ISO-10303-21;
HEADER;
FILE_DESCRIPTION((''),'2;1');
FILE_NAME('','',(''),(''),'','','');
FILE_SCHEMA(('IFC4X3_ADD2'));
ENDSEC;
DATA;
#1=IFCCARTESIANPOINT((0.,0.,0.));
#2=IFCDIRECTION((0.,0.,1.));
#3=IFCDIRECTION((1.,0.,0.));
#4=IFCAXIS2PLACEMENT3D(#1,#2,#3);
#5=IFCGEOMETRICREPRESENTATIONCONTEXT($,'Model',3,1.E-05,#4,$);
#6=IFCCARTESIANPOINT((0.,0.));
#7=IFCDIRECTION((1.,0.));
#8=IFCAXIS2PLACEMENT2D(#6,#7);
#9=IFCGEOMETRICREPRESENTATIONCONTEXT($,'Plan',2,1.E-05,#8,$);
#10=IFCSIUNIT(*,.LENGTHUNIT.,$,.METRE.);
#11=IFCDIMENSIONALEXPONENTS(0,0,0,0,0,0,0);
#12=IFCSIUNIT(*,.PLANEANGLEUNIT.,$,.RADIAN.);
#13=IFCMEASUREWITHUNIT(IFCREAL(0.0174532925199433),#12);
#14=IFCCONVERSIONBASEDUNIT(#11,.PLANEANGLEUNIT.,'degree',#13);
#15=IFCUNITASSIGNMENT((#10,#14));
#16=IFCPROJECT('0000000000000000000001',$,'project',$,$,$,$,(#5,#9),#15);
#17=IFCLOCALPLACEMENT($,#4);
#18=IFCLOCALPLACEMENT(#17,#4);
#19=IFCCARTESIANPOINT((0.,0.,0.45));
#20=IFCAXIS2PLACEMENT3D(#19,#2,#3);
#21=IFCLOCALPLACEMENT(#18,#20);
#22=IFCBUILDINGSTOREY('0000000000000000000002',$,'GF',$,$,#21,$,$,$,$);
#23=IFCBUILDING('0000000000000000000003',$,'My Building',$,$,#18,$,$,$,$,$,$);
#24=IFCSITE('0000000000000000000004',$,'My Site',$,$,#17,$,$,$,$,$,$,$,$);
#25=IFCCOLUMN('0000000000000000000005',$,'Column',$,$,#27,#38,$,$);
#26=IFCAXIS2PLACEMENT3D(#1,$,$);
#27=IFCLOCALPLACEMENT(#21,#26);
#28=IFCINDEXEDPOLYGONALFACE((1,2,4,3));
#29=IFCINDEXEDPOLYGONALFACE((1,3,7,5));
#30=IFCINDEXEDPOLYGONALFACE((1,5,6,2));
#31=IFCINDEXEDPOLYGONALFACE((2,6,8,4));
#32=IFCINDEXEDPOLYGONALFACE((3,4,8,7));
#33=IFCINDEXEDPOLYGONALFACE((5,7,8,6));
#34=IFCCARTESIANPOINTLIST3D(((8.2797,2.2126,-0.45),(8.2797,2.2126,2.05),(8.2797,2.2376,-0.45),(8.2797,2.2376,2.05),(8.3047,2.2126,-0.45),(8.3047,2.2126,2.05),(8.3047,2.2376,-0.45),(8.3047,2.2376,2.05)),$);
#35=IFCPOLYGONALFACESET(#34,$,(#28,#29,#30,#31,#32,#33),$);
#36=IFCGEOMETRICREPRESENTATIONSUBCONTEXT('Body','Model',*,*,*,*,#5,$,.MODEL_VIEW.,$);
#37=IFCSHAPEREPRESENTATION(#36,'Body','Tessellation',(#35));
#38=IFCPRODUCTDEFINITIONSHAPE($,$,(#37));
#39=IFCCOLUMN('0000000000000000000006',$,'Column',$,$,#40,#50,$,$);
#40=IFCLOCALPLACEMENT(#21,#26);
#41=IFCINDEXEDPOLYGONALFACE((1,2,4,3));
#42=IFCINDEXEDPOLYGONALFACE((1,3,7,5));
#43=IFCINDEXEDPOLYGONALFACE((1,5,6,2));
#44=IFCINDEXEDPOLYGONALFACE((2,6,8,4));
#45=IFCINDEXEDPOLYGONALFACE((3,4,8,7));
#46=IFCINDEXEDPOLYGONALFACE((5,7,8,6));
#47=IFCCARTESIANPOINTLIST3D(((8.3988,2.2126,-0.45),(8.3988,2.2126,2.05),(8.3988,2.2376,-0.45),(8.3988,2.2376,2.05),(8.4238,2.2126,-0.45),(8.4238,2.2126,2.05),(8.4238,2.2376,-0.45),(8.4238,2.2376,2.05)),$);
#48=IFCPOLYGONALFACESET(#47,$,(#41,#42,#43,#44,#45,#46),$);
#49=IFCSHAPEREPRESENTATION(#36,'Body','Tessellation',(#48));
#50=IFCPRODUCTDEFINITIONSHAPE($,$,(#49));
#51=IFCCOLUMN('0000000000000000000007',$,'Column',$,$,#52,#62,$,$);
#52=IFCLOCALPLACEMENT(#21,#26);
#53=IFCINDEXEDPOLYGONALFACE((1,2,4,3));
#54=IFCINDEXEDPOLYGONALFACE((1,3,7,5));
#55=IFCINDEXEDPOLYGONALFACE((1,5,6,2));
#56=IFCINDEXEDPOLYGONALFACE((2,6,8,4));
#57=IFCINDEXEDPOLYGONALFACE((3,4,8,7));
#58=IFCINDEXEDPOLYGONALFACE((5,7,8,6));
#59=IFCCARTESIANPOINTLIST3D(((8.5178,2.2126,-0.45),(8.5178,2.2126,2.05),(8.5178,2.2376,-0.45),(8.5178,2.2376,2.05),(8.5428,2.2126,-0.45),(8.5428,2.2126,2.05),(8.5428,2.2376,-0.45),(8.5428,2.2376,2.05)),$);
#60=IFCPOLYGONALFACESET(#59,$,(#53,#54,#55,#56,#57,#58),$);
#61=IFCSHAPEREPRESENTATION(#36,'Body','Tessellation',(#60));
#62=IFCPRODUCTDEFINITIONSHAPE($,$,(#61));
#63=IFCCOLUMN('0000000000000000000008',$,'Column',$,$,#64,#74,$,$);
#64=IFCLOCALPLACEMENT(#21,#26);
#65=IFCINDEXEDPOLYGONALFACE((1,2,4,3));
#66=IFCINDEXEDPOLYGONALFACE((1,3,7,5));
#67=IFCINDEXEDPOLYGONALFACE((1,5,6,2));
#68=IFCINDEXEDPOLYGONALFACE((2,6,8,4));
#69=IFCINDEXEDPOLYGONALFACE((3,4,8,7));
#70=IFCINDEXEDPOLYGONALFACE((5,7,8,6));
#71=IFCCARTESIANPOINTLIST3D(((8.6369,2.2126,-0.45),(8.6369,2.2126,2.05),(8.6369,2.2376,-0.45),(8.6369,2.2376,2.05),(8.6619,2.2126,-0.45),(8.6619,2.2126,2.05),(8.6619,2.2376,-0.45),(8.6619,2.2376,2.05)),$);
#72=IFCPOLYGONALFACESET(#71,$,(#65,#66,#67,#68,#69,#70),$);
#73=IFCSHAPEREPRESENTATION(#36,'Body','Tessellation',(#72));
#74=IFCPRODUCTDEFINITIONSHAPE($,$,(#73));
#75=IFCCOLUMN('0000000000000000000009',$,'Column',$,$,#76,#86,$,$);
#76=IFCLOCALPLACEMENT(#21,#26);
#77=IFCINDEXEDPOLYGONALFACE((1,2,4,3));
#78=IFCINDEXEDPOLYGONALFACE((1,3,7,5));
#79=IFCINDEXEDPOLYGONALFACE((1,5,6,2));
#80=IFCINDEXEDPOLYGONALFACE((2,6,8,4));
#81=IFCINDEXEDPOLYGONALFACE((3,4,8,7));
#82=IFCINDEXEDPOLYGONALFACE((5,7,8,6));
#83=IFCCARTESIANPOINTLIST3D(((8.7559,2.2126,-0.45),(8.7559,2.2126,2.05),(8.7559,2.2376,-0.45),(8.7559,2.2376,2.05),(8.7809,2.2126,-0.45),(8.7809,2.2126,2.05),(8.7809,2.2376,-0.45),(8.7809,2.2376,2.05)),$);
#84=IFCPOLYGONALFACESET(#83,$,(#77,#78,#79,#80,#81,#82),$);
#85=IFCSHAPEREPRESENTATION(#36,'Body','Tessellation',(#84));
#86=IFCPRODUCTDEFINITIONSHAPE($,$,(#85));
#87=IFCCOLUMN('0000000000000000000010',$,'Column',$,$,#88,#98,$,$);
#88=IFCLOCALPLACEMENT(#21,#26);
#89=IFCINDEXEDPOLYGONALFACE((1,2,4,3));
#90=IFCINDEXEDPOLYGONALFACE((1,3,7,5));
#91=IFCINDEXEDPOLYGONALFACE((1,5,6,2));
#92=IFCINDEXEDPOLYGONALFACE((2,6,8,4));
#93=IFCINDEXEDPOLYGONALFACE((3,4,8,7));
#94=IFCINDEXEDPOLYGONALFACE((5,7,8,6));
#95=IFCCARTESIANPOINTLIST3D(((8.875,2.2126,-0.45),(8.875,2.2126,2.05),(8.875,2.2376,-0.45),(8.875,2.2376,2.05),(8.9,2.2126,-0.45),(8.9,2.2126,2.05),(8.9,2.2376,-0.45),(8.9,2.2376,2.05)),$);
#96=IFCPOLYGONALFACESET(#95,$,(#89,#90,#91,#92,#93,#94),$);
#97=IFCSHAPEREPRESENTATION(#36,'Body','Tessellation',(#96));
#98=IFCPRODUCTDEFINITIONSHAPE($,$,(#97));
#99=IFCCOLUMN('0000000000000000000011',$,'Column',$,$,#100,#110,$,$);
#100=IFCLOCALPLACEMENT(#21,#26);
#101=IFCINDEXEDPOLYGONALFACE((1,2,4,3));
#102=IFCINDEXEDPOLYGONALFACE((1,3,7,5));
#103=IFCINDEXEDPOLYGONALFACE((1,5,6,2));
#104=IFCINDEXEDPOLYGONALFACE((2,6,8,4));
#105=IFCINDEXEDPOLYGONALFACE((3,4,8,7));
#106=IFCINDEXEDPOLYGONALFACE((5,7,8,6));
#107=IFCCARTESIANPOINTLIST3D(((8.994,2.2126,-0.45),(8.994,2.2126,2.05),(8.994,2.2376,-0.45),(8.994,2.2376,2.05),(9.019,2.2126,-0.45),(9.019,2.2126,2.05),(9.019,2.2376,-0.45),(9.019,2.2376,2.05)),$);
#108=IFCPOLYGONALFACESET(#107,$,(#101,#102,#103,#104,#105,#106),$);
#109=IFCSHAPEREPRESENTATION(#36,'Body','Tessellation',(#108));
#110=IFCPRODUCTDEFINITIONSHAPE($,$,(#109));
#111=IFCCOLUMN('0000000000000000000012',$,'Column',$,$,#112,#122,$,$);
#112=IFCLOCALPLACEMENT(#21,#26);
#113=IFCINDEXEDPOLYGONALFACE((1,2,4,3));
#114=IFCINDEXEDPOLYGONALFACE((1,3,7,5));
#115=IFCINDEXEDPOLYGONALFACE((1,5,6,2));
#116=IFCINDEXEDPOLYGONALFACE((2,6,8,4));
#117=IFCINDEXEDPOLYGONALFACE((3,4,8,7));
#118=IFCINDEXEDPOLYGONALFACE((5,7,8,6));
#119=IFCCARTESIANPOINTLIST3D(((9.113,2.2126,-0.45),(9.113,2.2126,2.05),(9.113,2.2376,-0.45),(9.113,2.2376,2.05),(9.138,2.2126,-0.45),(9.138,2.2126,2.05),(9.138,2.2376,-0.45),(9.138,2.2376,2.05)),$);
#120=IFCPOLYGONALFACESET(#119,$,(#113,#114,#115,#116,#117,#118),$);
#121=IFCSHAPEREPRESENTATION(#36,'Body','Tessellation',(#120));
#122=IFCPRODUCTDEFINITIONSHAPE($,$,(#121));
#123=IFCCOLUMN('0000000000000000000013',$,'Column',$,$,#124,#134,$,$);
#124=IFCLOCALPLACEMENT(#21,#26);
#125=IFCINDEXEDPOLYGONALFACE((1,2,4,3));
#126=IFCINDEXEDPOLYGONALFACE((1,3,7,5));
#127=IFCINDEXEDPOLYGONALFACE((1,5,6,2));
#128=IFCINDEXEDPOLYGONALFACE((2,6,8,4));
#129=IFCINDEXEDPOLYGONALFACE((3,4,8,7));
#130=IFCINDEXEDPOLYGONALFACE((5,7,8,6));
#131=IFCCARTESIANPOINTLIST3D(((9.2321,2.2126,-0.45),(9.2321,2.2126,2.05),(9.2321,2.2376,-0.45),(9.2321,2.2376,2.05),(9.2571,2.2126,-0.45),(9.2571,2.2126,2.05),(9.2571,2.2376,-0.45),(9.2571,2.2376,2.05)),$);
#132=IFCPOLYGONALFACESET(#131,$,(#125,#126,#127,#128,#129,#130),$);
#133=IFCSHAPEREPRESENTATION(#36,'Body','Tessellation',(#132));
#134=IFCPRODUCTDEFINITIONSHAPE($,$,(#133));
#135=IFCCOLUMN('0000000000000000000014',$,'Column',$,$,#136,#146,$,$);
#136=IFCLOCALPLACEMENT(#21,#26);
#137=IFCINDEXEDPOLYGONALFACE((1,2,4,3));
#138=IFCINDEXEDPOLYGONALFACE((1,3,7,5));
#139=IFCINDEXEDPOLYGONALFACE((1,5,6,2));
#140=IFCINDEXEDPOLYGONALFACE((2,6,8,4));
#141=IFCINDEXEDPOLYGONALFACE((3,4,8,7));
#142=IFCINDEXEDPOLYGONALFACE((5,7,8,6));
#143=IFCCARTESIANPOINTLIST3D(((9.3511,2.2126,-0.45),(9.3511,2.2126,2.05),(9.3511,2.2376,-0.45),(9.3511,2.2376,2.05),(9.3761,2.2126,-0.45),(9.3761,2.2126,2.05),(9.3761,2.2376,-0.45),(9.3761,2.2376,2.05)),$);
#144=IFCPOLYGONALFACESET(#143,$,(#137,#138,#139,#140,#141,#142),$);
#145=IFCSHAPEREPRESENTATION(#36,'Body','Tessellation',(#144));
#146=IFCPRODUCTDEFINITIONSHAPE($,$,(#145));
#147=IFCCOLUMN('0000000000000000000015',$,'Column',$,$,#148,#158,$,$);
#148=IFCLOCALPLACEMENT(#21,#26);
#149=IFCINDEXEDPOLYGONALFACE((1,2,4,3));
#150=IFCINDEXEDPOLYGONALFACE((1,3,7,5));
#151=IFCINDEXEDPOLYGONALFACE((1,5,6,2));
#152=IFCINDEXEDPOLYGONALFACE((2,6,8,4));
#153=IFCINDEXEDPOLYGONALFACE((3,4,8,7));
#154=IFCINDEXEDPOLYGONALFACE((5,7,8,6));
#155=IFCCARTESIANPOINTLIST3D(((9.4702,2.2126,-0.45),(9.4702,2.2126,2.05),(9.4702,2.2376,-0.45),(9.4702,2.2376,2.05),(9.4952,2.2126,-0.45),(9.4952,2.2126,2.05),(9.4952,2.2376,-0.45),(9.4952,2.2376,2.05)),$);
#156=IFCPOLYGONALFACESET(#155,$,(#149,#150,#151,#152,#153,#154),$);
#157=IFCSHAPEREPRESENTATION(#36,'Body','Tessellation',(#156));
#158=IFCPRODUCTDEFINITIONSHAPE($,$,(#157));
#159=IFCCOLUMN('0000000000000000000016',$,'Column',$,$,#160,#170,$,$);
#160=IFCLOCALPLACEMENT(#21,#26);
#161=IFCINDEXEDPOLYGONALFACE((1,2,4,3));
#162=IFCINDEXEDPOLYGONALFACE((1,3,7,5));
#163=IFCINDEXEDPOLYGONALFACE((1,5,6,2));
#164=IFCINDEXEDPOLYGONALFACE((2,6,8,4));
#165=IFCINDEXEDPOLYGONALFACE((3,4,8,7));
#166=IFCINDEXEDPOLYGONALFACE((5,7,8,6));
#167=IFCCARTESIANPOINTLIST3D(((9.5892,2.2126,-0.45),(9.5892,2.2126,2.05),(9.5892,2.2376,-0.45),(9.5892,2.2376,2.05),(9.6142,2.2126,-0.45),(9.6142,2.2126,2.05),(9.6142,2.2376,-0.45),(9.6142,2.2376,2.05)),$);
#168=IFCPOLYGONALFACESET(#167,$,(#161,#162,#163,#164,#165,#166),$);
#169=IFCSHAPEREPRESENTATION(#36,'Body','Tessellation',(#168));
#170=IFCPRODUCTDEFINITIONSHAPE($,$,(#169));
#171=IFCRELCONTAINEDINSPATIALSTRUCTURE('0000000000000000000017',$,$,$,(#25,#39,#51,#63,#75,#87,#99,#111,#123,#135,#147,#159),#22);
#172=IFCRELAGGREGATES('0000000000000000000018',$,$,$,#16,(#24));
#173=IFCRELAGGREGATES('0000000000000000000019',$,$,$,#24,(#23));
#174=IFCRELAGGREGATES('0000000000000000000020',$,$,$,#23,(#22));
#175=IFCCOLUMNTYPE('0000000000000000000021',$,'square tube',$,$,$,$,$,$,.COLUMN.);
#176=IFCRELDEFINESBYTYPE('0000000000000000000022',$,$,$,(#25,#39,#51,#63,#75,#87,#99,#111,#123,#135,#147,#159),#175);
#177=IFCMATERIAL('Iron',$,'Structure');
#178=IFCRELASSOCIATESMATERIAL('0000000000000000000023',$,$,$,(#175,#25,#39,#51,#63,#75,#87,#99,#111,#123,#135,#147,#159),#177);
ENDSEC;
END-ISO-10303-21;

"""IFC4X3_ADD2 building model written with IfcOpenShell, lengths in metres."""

from ifc_helpers import new_model, entity, si_unit, converted_unit, frame, origin_with_axes, origin_2d_with_axis, place, context, subcontext, project, spatial, indexed_curve, outline, extrude, material, material_profile, profile_set, profile_usage, type_object, element, save


model = new_model("IFC4X3_ADD2")

# Units and contexts
model_context = context("Model", 3, precision=1e-05, world=origin_with_axes())
plan_context = context("Plan", 2, precision=1e-05, world=origin_2d_with_axis())
body_context = subcontext(model_context, "Body", "Model", "MODEL_VIEW")
ifc_project = project(units=[si_unit("LENGTHUNIT", "METRE"), converted_unit("PLANEANGLEUNIT", "degree", entity("IfcReal", 0.0174532925199433), si_unit("PLANEANGLEUNIT", "RADIAN"), dimensions=[0, 0, 0, 0, 0, 0, 0])], contexts=[model_context, plan_context])

# Site, building, storey
site_placement = place(None, origin_with_axes())
site = spatial("IfcSite", under=ifc_project, at=site_placement, Name="My Site")
building_placement = place(site_placement, origin_with_axes())
building = spatial("IfcBuilding", under=site, at=building_placement, Name="My Building")
storey_placement = place(building_placement, frame((0.0, 0.0, 0.45), z_axis=(0.0, 0.0, 1.0), x_axis=(1.0, 0.0, 0.0)))
storey = spatial("IfcBuildingStorey", under=building, at=storey_placement, Name="GF")

# Columns
ifc_material_1 = material(Name="Iron", Category="Structure")
ifc_material_profile = material_profile(ifc_material_1, outline(indexed_curve([(-0.0125, -0.0125), (0.0125, -0.0125), (0.0125, 0.0125), (-0.0125, 0.0125), (-0.0125, -0.0125)])))
ifc_profile_set = profile_set([ifc_material_profile])
column_type = type_object("IfcColumnType", Name="square tube", PredefinedType="COLUMN", material=ifc_profile_set)
ifc_profile_usage_1 = profile_usage(ifc_profile_set, cardinal=5)
column_1_placement = place(storey_placement, frame((8.2922, 2.2251, -0.45), z_axis=(0.0, 0.0, 1.0), x_axis=(1.0, 0.0, 0.0)))
element("IfcColumn", 1, at=column_1_placement, inside=storey, type_object=column_type, material=ifc_profile_usage_1, Name="Column", context=body_context, shape_type="SweptSolid", body=[
    extrude(outline(indexed_curve([(-0.0125, -0.0125), (0.0125, -0.0125), (0.0125, 0.0125), (-0.0125, 0.0125), (-0.0125, -0.0125)])), origin_with_axes(), (0.0, 0.0, 1.0), 2.5),
])
ifc_profile_usage_2 = profile_usage(ifc_profile_set, cardinal=5)
column_2_placement = place(storey_placement, frame((8.4113, 2.2251, -0.45), z_axis=(0.0, 0.0, 1.0), x_axis=(1.0, 0.0, 0.0)))
element("IfcColumn", 2, at=column_2_placement, inside=storey, type_object=column_type, material=ifc_profile_usage_2, Name="Column", context=body_context, shape_type="SweptSolid", body=[
    extrude(outline(indexed_curve([(-0.0125, -0.0125), (0.0125, -0.0125), (0.0125, 0.0125), (-0.0125, 0.0125), (-0.0125, -0.0125)])), origin_with_axes(), (0.0, 0.0, 1.0), 2.5),
])
ifc_profile_usage_3 = profile_usage(ifc_profile_set, cardinal=5)
column_3_placement = place(storey_placement, frame((8.5303, 2.2251, -0.45), z_axis=(0.0, 0.0, 1.0), x_axis=(1.0, 0.0, 0.0)))
element("IfcColumn", 3, at=column_3_placement, inside=storey, type_object=column_type, material=ifc_profile_usage_3, Name="Column", context=body_context, shape_type="SweptSolid", body=[
    extrude(outline(indexed_curve([(-0.0125, -0.0125), (0.0125, -0.0125), (0.0125, 0.0125), (-0.0125, 0.0125), (-0.0125, -0.0125)])), origin_with_axes(), (0.0, 0.0, 1.0), 2.5),
])
ifc_profile_usage_4 = profile_usage(ifc_profile_set, cardinal=5)
column_4_placement = place(storey_placement, frame((8.6494, 2.2251, -0.45), z_axis=(0.0, 0.0, 1.0), x_axis=(1.0, 0.0, 0.0)))
element("IfcColumn", 4, at=column_4_placement, inside=storey, type_object=column_type, material=ifc_profile_usage_4, Name="Column", context=body_context, shape_type="SweptSolid", body=[
    extrude(outline(indexed_curve([(-0.0125, -0.0125), (0.0125, -0.0125), (0.0125, 0.0125), (-0.0125, 0.0125), (-0.0125, -0.0125)])), origin_with_axes(), (0.0, 0.0, 1.0), 2.5),
])
ifc_profile_usage_5 = profile_usage(ifc_profile_set, cardinal=5)
column_5_placement = place(storey_placement, frame((8.7684, 2.2251, -0.45), z_axis=(0.0, 0.0, 1.0), x_axis=(1.0, 0.0, 0.0)))
element("IfcColumn", 5, at=column_5_placement, inside=storey, type_object=column_type, material=ifc_profile_usage_5, Name="Column", context=body_context, shape_type="SweptSolid", body=[
    extrude(outline(indexed_curve([(-0.0125, -0.0125), (0.0125, -0.0125), (0.0125, 0.0125), (-0.0125, 0.0125), (-0.0125, -0.0125)])), origin_with_axes(), (0.0, 0.0, 1.0), 2.5),
])
ifc_profile_usage_6 = profile_usage(ifc_profile_set, cardinal=5)
column_6_placement = place(storey_placement, frame((8.8875, 2.2251, -0.45), z_axis=(0.0, 0.0, 1.0), x_axis=(1.0, 0.0, 0.0)))
element("IfcColumn", 6, at=column_6_placement, inside=storey, type_object=column_type, material=ifc_profile_usage_6, Name="Column", context=body_context, shape_type="SweptSolid", body=[
    extrude(outline(indexed_curve([(-0.0125, -0.0125), (0.0125, -0.0125), (0.0125, 0.0125), (-0.0125, 0.0125), (-0.0125, -0.0125)])), origin_with_axes(), (0.0, 0.0, 1.0), 2.5),
])
ifc_profile_usage_7 = profile_usage(ifc_profile_set, cardinal=5)
column_7_placement = place(storey_placement, frame((9.0065, 2.2251, -0.45), z_axis=(0.0, 0.0, 1.0), x_axis=(1.0, 0.0, 0.0)))
element("IfcColumn", 7, at=column_7_placement, inside=storey, type_object=column_type, material=ifc_profile_usage_7, Name="Column", context=body_context, shape_type="SweptSolid", body=[
    extrude(outline(indexed_curve([(-0.0125, -0.0125), (0.0125, -0.0125), (0.0125, 0.0125), (-0.0125, 0.0125), (-0.0125, -0.0125)])), origin_with_axes(), (0.0, 0.0, 1.0), 2.5),
])
ifc_profile_usage_8 = profile_usage(ifc_profile_set, cardinal=5)
column_8_placement = place(storey_placement, frame((9.1255, 2.2251, -0.45), z_axis=(0.0, 0.0, 1.0), x_axis=(1.0, 0.0, 0.0)))
element("IfcColumn", 8, at=column_8_placement, inside=storey, type_object=column_type, material=ifc_profile_usage_8, Name="Column", context=body_context, shape_type="SweptSolid", body=[
    extrude(outline(indexed_curve([(-0.0125, -0.0125), (0.0125, -0.0125), (0.0125, 0.0125), (-0.0125, 0.0125), (-0.0125, -0.0125)])), origin_with_axes(), (0.0, 0.0, 1.0), 2.5),
])
ifc_profile_usage_9 = profile_usage(ifc_profile_set, cardinal=5)
column_9_placement = place(storey_placement, frame((9.2446, 2.2251, -0.45), z_axis=(0.0, 0.0, 1.0), x_axis=(1.0, 0.0, 0.0)))
element("IfcColumn", 9, at=column_9_placement, inside=storey, type_object=column_type, material=ifc_profile_usage_9, Name="Column", context=body_context, shape_type="SweptSolid", body=[
    extrude(outline(indexed_curve([(-0.0125, -0.0125), (0.0125, -0.0125), (0.0125, 0.0125), (-0.0125, 0.0125), (-0.0125, -0.0125)])), origin_with_axes(), (0.0, 0.0, 1.0), 2.5),
])
ifc_profile_usage_10 = profile_usage(ifc_profile_set, cardinal=5)
column_10_placement = place(storey_placement, frame((9.3636, 2.2251, -0.45), z_axis=(0.0, 0.0, 1.0), x_axis=(1.0, 0.0, 0.0)))
element("IfcColumn", 10, at=column_10_placement, inside=storey, type_object=column_type, material=ifc_profile_usage_10, Name="Column", context=body_context, shape_type="SweptSolid", body=[
    extrude(outline(indexed_curve([(-0.0125, -0.0125), (0.0125, -0.0125), (0.0125, 0.0125), (-0.0125, 0.0125), (-0.0125, -0.0125)])), origin_with_axes(), (0.0, 0.0, 1.0), 2.5),
])
ifc_profile_usage_11 = profile_usage(ifc_profile_set, cardinal=5)
column_11_placement = place(storey_placement, frame((9.4827, 2.2251, -0.45), z_axis=(0.0, 0.0, 1.0), x_axis=(1.0, 0.0, 0.0)))
element("IfcColumn", 11, at=column_11_placement, inside=storey, type_object=column_type, material=ifc_profile_usage_11, Name="Column", context=body_context, shape_type="SweptSolid", body=[
    extrude(outline(indexed_curve([(-0.0125, -0.0125), (0.0125, -0.0125), (0.0125, 0.0125), (-0.0125, 0.0125), (-0.0125, -0.0125)])), origin_with_axes(), (0.0, 0.0, 1.0), 2.5),
])
ifc_profile_usage_12 = profile_usage(ifc_profile_set, cardinal=5)
column_12_placement = place(storey_placement, frame((9.6017, 2.2251, -0.45), z_axis=(0.0, 0.0, 1.0), x_axis=(1.0, 0.0, 0.0)))
element("IfcColumn", 12, at=column_12_placement, inside=storey, type_object=column_type, material=ifc_profile_usage_12, Name="Column", context=body_context, shape_type="SweptSolid", body=[
    extrude(outline(indexed_curve([(-0.0125, -0.0125), (0.0125, -0.0125), (0.0125, 0.0125), (-0.0125, 0.0125), (-0.0125, -0.0125)])), origin_with_axes(), (0.0, 0.0, 1.0), 2.5),
])

save(model, "model.ifc")
